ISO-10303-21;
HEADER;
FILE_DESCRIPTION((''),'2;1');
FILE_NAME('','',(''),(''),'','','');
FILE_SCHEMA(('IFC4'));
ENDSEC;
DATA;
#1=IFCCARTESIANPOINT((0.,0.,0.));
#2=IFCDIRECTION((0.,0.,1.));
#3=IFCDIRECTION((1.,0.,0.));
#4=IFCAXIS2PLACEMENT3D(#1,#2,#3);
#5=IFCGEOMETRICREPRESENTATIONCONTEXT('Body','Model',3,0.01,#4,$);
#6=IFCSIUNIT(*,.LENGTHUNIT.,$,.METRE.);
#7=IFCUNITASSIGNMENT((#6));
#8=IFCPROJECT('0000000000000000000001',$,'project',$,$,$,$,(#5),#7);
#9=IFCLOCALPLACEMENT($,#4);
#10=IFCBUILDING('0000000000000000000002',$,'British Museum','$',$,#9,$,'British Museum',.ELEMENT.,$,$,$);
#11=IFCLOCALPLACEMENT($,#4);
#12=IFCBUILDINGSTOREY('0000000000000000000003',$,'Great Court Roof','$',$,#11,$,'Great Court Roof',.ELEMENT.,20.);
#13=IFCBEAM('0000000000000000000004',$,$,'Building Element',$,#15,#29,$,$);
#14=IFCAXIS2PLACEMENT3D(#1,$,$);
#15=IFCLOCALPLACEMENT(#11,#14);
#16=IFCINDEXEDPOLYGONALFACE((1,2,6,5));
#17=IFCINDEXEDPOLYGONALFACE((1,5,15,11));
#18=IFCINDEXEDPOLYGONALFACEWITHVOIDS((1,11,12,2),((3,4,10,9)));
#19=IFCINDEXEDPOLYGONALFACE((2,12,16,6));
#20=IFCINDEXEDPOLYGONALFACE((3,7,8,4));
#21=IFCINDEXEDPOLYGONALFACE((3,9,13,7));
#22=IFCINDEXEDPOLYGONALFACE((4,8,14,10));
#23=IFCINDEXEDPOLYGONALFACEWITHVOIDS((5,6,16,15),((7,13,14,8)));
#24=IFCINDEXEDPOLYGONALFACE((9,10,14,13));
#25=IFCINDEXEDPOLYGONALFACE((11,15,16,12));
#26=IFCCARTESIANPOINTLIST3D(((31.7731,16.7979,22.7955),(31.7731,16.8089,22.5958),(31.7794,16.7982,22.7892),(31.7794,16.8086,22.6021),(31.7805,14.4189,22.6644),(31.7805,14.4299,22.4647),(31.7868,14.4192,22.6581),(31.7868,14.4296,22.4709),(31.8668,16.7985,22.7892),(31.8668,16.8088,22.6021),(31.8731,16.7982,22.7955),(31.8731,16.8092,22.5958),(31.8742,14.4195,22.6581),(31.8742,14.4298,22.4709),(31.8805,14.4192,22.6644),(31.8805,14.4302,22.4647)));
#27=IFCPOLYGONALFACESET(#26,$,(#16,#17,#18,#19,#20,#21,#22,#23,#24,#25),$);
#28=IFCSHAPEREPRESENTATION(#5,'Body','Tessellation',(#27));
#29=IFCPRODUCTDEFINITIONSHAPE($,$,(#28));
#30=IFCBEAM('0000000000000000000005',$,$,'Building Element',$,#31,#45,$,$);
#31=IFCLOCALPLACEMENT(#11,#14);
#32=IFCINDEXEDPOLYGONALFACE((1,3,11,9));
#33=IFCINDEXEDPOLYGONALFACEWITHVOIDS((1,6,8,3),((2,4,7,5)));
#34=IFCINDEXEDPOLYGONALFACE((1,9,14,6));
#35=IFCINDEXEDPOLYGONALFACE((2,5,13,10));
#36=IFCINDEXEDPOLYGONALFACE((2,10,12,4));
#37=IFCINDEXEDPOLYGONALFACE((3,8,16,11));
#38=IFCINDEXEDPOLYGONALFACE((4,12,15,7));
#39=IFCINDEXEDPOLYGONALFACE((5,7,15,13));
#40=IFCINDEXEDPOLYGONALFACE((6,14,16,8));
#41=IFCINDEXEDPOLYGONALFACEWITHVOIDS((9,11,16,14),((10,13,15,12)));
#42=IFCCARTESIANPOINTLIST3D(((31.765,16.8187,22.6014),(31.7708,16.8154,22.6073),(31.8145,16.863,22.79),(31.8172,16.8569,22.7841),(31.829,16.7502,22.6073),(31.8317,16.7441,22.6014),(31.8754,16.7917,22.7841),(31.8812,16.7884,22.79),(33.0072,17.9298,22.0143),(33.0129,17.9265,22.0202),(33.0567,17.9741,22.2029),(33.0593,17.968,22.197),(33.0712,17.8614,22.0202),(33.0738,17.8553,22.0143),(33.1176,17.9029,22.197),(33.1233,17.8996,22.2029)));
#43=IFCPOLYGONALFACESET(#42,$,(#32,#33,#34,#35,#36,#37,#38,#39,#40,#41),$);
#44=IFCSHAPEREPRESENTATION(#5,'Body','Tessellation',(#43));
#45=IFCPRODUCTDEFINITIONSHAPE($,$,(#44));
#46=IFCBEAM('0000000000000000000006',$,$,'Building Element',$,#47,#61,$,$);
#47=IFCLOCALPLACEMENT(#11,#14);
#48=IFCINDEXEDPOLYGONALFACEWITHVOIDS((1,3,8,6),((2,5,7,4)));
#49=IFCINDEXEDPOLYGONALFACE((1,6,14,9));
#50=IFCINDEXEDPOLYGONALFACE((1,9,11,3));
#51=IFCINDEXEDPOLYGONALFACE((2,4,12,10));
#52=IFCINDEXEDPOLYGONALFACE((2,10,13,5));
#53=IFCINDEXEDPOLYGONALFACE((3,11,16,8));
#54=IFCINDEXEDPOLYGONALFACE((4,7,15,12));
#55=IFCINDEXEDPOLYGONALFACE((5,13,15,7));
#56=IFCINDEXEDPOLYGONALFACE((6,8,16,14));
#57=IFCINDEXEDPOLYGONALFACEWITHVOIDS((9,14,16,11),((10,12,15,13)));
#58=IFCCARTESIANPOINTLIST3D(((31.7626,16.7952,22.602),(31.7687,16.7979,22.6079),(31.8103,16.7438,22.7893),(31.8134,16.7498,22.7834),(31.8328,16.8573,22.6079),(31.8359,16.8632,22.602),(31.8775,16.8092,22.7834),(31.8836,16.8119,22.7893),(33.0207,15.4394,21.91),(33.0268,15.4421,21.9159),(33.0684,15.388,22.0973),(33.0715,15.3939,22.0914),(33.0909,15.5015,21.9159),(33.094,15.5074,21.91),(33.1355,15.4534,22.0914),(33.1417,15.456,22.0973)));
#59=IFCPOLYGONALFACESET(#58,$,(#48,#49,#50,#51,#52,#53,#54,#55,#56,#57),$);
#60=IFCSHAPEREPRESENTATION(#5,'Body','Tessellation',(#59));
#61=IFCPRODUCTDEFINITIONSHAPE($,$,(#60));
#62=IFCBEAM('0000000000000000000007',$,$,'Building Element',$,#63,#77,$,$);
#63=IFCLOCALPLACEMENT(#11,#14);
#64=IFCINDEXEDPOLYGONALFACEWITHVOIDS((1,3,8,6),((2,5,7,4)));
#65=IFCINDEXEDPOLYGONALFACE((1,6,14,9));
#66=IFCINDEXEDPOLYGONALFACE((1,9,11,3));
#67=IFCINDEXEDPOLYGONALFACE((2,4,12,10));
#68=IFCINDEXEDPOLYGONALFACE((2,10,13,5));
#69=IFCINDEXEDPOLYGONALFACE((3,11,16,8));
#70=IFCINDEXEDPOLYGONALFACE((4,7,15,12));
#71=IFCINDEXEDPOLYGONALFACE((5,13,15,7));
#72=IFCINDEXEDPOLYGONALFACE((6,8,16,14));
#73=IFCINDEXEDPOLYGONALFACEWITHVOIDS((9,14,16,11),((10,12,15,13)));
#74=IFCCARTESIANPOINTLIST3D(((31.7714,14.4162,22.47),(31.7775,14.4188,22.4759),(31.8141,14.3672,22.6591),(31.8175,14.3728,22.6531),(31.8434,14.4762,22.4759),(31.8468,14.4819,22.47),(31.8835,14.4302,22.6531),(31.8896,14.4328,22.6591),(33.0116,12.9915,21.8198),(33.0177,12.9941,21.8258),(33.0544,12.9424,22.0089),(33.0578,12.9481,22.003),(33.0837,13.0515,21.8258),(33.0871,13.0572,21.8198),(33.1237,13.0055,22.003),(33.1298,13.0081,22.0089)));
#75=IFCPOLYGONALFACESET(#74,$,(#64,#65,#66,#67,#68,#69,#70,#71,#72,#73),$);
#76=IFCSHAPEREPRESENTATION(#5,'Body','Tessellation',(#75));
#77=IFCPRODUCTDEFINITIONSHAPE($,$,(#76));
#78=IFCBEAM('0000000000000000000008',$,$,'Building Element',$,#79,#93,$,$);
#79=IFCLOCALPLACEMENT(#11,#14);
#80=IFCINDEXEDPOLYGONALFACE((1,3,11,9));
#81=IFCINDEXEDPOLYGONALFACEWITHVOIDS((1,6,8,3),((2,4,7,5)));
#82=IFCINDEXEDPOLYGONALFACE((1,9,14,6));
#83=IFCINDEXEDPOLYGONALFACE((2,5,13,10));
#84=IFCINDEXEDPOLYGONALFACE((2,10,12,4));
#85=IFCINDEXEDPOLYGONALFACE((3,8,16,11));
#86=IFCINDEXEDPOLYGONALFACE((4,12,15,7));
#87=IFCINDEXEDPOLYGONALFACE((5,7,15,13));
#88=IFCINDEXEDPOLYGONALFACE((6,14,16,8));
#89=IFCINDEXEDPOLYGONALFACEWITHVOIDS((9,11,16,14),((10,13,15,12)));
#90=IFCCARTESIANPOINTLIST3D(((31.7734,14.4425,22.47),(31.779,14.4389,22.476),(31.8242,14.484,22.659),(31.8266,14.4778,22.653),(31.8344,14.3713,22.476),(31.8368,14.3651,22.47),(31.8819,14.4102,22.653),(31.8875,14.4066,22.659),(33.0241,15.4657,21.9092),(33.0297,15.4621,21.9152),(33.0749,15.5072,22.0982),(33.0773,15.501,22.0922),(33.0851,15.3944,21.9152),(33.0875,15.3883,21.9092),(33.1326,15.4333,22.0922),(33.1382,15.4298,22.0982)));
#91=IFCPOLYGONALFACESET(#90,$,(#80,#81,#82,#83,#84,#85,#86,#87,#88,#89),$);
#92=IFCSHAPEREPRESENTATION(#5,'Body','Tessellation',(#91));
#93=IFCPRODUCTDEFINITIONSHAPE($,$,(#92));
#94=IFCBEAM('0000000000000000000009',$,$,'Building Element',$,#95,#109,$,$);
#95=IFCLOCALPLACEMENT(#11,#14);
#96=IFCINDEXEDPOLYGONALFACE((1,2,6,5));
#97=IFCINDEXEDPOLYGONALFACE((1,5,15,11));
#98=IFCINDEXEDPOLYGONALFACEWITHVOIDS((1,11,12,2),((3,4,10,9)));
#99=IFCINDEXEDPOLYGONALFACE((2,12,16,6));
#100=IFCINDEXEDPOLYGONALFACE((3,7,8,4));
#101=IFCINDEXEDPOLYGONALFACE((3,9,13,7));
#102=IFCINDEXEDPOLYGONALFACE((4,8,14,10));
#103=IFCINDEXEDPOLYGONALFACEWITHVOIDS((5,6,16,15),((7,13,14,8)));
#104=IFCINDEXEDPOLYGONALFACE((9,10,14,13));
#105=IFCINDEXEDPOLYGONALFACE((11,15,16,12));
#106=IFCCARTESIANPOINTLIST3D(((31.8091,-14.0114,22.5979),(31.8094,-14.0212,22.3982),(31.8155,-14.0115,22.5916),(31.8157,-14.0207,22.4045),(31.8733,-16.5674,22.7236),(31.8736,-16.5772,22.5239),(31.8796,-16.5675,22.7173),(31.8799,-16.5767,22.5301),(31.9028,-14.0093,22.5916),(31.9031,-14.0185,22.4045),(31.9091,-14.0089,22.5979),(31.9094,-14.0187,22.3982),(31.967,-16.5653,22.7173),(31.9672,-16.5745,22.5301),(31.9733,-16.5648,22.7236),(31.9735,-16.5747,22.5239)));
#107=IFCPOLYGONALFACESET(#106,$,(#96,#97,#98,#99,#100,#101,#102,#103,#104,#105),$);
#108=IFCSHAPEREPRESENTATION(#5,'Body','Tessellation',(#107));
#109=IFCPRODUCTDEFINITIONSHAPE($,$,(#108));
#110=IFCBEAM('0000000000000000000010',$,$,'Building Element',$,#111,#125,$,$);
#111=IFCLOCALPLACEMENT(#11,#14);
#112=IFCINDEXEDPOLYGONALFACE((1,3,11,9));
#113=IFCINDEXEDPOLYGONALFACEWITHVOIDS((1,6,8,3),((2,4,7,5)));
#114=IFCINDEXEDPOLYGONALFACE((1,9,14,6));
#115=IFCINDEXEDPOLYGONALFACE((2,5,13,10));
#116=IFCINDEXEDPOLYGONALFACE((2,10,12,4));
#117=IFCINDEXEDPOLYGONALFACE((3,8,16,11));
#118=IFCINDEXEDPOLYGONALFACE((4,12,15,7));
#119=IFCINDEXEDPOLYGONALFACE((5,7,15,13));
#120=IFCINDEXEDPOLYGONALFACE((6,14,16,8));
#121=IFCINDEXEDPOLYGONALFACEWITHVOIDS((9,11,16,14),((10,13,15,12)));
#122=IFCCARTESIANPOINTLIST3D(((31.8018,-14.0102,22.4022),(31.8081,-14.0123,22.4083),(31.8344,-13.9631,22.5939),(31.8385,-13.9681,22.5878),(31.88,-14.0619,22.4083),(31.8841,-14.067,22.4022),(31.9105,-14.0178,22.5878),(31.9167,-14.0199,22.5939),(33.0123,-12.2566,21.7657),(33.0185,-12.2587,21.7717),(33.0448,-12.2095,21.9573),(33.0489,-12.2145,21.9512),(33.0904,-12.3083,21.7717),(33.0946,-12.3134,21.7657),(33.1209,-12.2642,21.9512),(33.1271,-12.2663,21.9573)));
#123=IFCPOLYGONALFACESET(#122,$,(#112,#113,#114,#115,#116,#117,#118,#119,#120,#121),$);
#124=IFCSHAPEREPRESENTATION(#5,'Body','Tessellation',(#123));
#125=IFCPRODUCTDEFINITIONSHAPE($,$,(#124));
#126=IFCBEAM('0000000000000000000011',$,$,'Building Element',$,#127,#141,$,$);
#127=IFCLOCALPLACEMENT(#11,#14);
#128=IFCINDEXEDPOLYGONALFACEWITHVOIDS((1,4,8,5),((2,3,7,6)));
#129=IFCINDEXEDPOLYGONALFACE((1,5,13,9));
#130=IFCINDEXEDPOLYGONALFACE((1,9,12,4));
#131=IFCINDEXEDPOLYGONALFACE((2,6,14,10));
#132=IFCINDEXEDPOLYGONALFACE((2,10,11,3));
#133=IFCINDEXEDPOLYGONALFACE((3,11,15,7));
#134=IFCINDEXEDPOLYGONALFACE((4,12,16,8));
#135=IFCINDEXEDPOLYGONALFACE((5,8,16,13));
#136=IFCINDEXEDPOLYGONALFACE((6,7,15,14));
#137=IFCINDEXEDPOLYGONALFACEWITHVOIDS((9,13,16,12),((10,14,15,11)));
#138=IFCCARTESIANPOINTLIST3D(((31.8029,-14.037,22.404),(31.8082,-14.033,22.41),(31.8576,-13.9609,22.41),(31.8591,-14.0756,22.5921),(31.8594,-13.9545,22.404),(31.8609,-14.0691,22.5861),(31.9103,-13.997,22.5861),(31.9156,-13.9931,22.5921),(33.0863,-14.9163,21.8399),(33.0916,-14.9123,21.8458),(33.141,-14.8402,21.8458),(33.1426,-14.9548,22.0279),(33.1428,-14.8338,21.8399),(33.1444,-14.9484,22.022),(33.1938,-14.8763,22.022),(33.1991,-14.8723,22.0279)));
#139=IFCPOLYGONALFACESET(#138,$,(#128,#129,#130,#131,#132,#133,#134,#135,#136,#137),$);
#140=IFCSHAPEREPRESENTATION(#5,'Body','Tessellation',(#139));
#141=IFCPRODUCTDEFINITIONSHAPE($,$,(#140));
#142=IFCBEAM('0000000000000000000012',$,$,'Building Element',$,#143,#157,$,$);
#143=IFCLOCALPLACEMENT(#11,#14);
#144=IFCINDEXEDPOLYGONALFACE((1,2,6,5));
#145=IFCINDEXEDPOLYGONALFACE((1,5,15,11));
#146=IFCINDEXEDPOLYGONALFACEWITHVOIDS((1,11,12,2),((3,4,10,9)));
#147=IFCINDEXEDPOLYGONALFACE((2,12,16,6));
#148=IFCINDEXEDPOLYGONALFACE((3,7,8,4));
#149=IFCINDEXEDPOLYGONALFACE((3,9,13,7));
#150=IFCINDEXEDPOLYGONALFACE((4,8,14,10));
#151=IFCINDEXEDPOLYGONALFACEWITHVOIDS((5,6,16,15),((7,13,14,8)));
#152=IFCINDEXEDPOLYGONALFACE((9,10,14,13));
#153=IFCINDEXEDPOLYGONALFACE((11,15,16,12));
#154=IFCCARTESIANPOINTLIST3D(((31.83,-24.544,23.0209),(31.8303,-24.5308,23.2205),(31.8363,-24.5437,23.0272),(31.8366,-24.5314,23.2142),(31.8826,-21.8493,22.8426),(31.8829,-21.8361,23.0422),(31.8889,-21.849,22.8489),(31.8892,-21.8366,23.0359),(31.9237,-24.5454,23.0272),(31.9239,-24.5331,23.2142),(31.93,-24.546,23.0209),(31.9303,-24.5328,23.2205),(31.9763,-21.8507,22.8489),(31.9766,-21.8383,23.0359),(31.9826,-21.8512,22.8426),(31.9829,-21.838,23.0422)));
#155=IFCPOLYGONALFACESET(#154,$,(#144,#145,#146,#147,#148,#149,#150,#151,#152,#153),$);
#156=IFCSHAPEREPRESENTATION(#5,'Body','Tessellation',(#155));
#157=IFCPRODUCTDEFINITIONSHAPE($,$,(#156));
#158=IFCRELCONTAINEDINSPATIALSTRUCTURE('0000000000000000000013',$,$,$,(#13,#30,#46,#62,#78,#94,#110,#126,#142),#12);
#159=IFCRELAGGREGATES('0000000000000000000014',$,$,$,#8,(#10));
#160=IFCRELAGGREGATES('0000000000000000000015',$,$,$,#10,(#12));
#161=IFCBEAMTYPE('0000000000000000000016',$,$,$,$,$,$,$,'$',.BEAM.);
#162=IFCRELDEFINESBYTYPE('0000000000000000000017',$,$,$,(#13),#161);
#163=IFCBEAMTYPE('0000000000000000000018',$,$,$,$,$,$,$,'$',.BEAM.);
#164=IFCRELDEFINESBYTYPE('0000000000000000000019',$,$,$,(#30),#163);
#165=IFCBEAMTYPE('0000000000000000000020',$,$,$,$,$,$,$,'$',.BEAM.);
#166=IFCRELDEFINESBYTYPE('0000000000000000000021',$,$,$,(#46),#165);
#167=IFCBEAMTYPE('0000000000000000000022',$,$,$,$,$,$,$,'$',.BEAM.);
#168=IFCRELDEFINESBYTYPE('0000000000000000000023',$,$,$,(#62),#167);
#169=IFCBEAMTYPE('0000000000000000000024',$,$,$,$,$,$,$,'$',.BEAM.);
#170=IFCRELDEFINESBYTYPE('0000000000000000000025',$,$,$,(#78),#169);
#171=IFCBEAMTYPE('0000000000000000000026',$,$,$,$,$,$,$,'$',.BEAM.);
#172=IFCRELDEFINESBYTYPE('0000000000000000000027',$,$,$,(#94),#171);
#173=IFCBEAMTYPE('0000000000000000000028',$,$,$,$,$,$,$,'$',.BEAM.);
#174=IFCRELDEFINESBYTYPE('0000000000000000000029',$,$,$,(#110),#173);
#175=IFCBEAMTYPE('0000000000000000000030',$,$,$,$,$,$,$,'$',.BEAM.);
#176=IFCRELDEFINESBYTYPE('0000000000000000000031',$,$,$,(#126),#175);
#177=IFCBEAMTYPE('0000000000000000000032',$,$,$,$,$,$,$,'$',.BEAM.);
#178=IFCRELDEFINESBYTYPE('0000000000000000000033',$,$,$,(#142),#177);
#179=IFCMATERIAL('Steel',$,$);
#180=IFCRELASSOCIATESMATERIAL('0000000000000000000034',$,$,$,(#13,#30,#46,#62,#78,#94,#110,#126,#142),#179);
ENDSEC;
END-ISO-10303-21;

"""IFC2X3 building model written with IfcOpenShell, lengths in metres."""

from ifc_helpers import new_model, si_unit, frame, origin_with_axes, origin_2d, place, context, project, spatial, hollow_rectangle, extrude, material, type_object, element, save


model = new_model("IFC2X3")

# Units and contexts
model_context = context("Model", 3, precision=0.01, world=origin_with_axes(), identifier="Body")
ifc_project = project(units=[si_unit("LENGTHUNIT", "METRE")], contexts=[model_context])

# Building, storey
building_placement = place(None, origin_with_axes())
building = spatial("IfcBuilding", under=ifc_project, at=building_placement, Name="British Museum", Description="$", LongName="British Museum", CompositionType="ELEMENT")
storey_placement = place(None, origin_with_axes())
storey = spatial("IfcBuildingStorey", under=building, at=storey_placement, Name="Great Court Roof", Description="$", LongName="Great Court Roof", CompositionType="ELEMENT", Elevation=20.0)

# Beams
ifc_material = material(Name="Steel")
beam_type_1 = type_object("IfcBeamType", ElementType="$", PredefinedType="BEAM")
beam_1_placement = place(None, origin_with_axes())
element("IfcBeam", 1, at=beam_1_placement, inside=storey, type_object=beam_type_1, material=ifc_material, Description="Building Element", context=model_context, shape_type="SweptSolid", body=[
    extrude(hollow_rectangle(XDim=0.1, YDim=0.2, WallThickness=0.0063, InnerFilletRadius=-0.0063, OuterFilletRadius=0.0, at=origin_2d()), frame((31.8231, 16.8035, 22.6957), z_axis=(0.003098, -0.998478, -0.055057), x_axis=(0.999995, 0.003103, 0.0)), (0.0, 0.0, 1.0), 2.3826),
])
beam_type_2 = type_object("IfcBeamType", ElementType="$", PredefinedType="BEAM")
beam_2_placement = place(None, origin_with_axes())
element("IfcBeam", 2, at=beam_2_placement, inside=storey, type_object=beam_type_2, material=ifc_material, Description="Building Element", context=model_context, shape_type="SweptSolid", body=[
    extrude(hollow_rectangle(XDim=0.1, YDim=0.2, WallThickness=0.0063, InnerFilletRadius=-0.0063, OuterFilletRadius=0.0, at=origin_2d()), frame((31.8231, 16.8035, 22.6957), z_axis=(0.70297, 0.628837, -0.332261), x_axis=(-0.666715, 0.745313, 0.0)), (0.0, 0.0, 1.0), 1.767),
])
beam_type_3 = type_object("IfcBeamType", ElementType="$", PredefinedType="BEAM")
beam_3_placement = place(None, origin_with_axes())
element("IfcBeam", 3, at=beam_3_placement, inside=storey, type_object=beam_type_3, material=ifc_material, Description="Building Element", context=model_context, shape_type="SweptSolid", body=[
    extrude(hollow_rectangle(XDim=0.1, YDim=0.2, WallThickness=0.0063, InnerFilletRadius=-0.0063, OuterFilletRadius=0.0, at=origin_2d()), frame((31.8231, 16.8035, 22.6957), z_axis=(0.637062, -0.686557, -0.350416), x_axis=(0.733036, 0.68019, 0.0)), (0.0, 0.0, 1.0), 1.9748),
])
beam_type_4 = type_object("IfcBeamType", ElementType="$", PredefinedType="BEAM")
beam_4_placement = place(None, origin_with_axes())
element("IfcBeam", 4, at=beam_4_placement, inside=storey, type_object=beam_type_4, material=ifc_material, Description="Building Element", context=model_context, shape_type="SweptSolid", body=[
    extrude(hollow_rectangle(XDim=0.1, YDim=0.2, WallThickness=0.0063, InnerFilletRadius=-0.0063, OuterFilletRadius=0.0, at=origin_2d()), frame((31.8305, 14.4245, 22.5645), z_axis=(0.620841, -0.713195, -0.325437), x_axis=(0.754254, 0.656583, 0.0)), (0.0, 0.0, 1.0), 1.9977),
])
beam_type_5 = type_object("IfcBeamType", ElementType="$", PredefinedType="BEAM")
beam_5_placement = place(None, origin_with_axes())
element("IfcBeam", 5, at=beam_5_placement, inside=storey, type_object=beam_type_5, material=ifc_material, Description="Building Element", context=model_context, shape_type="SweptSolid", body=[
    extrude(hollow_rectangle(XDim=0.1, YDim=0.2, WallThickness=0.0063, InnerFilletRadius=-0.0063, OuterFilletRadius=0.0, at=origin_2d()), frame((31.8305, 14.4245, 22.5645), z_axis=(0.731205, 0.598192, -0.32788), x_axis=(-0.633195, 0.773992, 0.0)), (0.0, 0.0, 1.0), 1.7105),
])
beam_type_6 = type_object("IfcBeamType", ElementType="$", PredefinedType="BEAM")
beam_6_placement = place(None, origin_with_axes())
element("IfcBeam", 6, at=beam_6_placement, inside=storey, type_object=beam_type_6, material=ifc_material, Description="Building Element", context=model_context, shape_type="SweptSolid", body=[
    extrude(hollow_rectangle(XDim=0.1, YDim=0.2, WallThickness=0.0063, InnerFilletRadius=-0.0063, OuterFilletRadius=0.0, at=origin_2d()), frame((31.8593, -14.015, 22.498), z_axis=(0.025073, -0.998479, 0.049098), x_axis=(0.999685, 0.025103, 0.0)), (0.0, 0.0, 1.0), 2.5599),
])
beam_type_7 = type_object("IfcBeamType", ElementType="$", PredefinedType="BEAM")
beam_7_placement = place(None, origin_with_axes())
element("IfcBeam", 7, at=beam_7_placement, inside=storey, type_object=beam_type_7, material=ifc_material, Description="Building Element", context=model_context, shape_type="SweptSolid", body=[
    extrude(hollow_rectangle(XDim=0.1, YDim=0.2, WallThickness=0.0063, InnerFilletRadius=-0.0063, OuterFilletRadius=0.0, at=origin_2d()), frame((31.8593, -14.015, 22.498), z_axis=(0.544293, 0.788546, -0.286253), x_axis=(-0.822984, 0.568064, 0.0)), (0.0, 0.0, 1.0), 2.2238),
])
beam_type_8 = type_object("IfcBeamType", ElementType="$", PredefinedType="BEAM")
beam_8_placement = place(None, origin_with_axes())
element("IfcBeam", 8, at=beam_8_placement, inside=storey, type_object=beam_type_8, material=ifc_material, Description="Building Element", context=model_context, shape_type="SweptSolid", body=[
    extrude(hollow_rectangle(XDim=0.1, YDim=0.2, WallThickness=0.0063, InnerFilletRadius=-0.0063, OuterFilletRadius=0.0, at=origin_2d()), frame((31.8593, -14.015, 22.498), z_axis=(0.775549, -0.531325, -0.340906), x_axis=(0.565181, 0.824967, 0.0)), (0.0, 0.0, 1.0), 1.6549),
])
beam_type_9 = type_object("IfcBeamType", ElementType="$", PredefinedType="BEAM")
beam_9_placement = place(None, origin_with_axes())
element("IfcBeam", 9, at=beam_9_placement, inside=storey, type_object=beam_type_9, material=ifc_material, Description="Building Element", context=model_context, shape_type="SweptSolid", body=[
    extrude(hollow_rectangle(XDim=0.1, YDim=0.2, WallThickness=0.0063, InnerFilletRadius=-0.0063, OuterFilletRadius=0.0, at=origin_2d()), frame((31.8801, -24.5384, 23.1207), z_axis=(0.019477, 0.997628, -0.066023), x_axis=(-0.999809, 0.019519, 0.0)), (0.0, 0.0, 1.0), 2.7011),
])

save(model, "model.ifc")
